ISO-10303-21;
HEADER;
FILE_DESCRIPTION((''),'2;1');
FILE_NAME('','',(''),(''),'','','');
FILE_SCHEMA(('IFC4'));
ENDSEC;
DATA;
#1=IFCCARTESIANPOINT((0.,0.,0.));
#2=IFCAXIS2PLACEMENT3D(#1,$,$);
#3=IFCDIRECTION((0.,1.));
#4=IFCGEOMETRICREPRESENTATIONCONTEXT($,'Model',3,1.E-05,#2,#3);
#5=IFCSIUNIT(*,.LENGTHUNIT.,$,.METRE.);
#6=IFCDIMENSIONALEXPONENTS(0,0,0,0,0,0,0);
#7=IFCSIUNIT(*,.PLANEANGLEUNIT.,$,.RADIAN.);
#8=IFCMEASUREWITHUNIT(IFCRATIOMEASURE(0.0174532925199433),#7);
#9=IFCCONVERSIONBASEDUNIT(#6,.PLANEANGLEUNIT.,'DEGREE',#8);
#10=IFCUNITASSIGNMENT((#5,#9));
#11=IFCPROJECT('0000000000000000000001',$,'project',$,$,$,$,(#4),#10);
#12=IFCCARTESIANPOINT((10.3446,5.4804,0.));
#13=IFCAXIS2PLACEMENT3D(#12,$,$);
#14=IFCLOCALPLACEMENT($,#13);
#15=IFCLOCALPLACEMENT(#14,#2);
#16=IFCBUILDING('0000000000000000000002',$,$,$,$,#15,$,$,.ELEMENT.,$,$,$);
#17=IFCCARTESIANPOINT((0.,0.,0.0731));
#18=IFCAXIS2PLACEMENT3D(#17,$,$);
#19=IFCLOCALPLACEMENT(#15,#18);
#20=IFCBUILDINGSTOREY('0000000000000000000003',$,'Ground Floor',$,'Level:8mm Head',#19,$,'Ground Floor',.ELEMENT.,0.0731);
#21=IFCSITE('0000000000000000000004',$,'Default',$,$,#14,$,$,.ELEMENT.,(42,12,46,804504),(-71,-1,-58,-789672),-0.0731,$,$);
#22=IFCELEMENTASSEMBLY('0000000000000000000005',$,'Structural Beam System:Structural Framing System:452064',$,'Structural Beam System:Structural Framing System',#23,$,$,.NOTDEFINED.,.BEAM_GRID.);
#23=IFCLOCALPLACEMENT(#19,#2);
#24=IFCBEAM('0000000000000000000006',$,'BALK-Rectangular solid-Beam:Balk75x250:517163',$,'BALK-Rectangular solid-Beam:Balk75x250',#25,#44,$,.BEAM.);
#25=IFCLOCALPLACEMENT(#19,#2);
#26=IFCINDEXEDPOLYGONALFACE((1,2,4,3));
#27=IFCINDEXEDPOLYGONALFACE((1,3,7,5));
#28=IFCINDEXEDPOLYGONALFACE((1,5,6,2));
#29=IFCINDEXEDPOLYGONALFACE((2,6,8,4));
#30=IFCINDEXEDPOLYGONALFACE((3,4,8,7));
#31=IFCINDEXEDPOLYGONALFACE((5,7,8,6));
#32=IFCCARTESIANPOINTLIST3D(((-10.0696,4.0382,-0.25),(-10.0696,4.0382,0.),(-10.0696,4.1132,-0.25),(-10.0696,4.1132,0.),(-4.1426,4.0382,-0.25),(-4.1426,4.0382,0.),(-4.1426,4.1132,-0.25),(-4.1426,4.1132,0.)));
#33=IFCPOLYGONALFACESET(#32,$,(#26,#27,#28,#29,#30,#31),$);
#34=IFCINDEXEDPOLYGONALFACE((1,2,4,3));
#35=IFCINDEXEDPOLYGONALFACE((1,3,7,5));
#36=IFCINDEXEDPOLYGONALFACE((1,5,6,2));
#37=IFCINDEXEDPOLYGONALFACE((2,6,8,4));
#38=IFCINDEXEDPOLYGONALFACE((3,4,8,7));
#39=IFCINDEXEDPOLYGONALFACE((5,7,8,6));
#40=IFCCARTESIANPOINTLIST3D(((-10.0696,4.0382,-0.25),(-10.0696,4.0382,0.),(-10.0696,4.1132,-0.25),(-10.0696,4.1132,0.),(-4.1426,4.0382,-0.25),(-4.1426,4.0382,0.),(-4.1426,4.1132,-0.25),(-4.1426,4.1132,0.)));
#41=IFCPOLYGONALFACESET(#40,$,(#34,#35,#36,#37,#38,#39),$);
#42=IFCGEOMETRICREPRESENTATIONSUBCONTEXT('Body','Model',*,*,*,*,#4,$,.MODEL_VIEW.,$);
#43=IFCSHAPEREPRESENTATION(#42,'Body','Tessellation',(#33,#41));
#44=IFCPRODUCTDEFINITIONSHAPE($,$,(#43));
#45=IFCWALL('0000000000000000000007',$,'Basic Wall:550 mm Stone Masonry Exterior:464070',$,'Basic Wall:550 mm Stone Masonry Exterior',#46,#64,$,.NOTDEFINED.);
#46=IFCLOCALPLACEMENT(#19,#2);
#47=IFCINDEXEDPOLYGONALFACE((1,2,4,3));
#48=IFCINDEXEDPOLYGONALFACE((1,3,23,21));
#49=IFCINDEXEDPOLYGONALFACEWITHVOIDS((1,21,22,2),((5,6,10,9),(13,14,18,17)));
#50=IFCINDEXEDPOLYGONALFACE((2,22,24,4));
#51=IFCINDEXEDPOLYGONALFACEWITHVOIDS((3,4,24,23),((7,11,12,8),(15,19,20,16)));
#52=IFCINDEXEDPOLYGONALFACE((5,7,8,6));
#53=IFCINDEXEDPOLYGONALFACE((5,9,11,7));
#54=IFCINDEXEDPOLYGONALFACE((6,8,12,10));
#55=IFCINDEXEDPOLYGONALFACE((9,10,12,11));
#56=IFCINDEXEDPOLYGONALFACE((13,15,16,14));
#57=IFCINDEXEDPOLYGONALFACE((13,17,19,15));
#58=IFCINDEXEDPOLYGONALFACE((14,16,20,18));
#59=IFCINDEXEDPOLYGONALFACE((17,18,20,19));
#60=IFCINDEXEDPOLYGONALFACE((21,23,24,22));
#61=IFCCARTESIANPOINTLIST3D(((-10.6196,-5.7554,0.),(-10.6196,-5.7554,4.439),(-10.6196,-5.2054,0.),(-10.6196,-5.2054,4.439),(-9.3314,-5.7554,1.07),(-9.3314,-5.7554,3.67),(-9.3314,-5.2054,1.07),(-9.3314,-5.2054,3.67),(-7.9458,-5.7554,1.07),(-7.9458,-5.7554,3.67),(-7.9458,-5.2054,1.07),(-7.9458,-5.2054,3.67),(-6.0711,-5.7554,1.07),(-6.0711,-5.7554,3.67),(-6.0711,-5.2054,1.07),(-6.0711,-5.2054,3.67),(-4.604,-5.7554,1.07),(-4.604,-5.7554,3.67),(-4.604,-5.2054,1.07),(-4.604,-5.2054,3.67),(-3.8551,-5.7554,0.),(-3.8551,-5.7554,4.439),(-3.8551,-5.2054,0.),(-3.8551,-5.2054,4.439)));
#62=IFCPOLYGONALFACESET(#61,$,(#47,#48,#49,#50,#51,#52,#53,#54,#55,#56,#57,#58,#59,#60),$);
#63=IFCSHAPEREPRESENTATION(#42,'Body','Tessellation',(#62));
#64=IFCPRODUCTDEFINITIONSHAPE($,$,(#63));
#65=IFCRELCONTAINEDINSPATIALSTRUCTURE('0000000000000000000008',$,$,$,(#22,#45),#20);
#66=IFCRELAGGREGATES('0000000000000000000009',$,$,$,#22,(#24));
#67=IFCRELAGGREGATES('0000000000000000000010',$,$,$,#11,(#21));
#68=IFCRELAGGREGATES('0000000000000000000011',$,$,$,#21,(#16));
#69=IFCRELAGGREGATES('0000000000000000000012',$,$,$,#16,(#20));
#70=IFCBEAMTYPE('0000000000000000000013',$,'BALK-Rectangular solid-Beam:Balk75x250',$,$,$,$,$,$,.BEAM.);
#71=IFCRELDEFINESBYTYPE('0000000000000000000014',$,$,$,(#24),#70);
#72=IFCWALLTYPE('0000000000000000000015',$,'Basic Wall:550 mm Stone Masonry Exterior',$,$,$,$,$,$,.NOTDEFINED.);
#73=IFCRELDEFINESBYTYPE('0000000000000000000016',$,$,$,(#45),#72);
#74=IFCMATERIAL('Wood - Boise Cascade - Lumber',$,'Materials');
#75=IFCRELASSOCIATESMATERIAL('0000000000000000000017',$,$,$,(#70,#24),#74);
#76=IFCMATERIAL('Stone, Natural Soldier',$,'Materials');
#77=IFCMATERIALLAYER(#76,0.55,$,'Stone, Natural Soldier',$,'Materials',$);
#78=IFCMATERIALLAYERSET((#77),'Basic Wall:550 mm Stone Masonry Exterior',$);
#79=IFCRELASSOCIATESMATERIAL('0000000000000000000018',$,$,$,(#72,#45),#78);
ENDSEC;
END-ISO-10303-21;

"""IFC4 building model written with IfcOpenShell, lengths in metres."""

from ifc_helpers import new_model, entity, si_unit, converted_unit, direction, frame, frame_2d, origin, origin_2d_with_axis, place, context, subcontext, project, spatial, rectangle, extrude, source, transform, mapped, material, layer, layer_set, layer_usage, material_profile, profile_set, profile_usage, type_object, type_shapes, element, aggregate, save


model = new_model("IFC4")

# Units and contexts
model_context = context("Model", 3, precision=1e-05, world=origin(), true_north=direction((0.0, 1.0)))
body_context = subcontext(model_context, "Body", "Model", "MODEL_VIEW")
ifc_project = project(units=[si_unit("LENGTHUNIT", "METRE"), converted_unit("PLANEANGLEUNIT", "DEGREE", entity("IfcRatioMeasure", 0.0174532925199433), si_unit("PLANEANGLEUNIT", "RADIAN"), dimensions=[0, 0, 0, 0, 0, 0, 0])], contexts=[model_context])

# Site, building, storey
site_placement = place(None, frame((10.3446, 5.4804, 0.0)))
site = spatial("IfcSite", under=ifc_project, at=site_placement, Name="Default", CompositionType="ELEMENT", RefLatitude=(42, 12, 46, 804504), RefLongitude=(-71, -1, -58, -789672), RefElevation=-0.0731)
building_placement = place(site_placement, origin())
building = spatial("IfcBuilding", under=site, at=building_placement, CompositionType="ELEMENT")
storey_placement = place(building_placement, frame((0.0, 0.0, 0.0731)))
storey = spatial("IfcBuildingStorey", under=building, at=storey_placement, Name="Ground Floor", ObjectType="Level:8mm Head", LongName="Ground Floor", CompositionType="ELEMENT", Elevation=0.0731)

# Element assembly, beam
assembly_placement = place(storey_placement, origin())
assembly = element("IfcElementAssembly", 1, at=assembly_placement, inside=storey, Name="Structural Beam System:Structural Framing System:452064", ObjectType="Structural Beam System:Structural Framing System", AssemblyPlace="NOTDEFINED", PredefinedType="BEAM_GRID")
ifc_material_1 = material(Name="Wood - Boise Cascade - Lumber", Category="Materials")
ifc_material_profile = material_profile(ifc_material_1, rectangle(XDim=0.25, YDim=0.075, at=frame_2d((0.0, 0.0), x_axis=(1.0, 0.0))), Name="Balk75x250")
ifc_profile_set = profile_set([ifc_material_profile], Name="Balk75x250")
beam_type = type_object("IfcBeamType", Name="BALK-Rectangular solid-Beam:Balk75x250", PredefinedType="BEAM", material=ifc_profile_set)
shared_shape = source(origin(), body_context, "Body", "SweptSolid", [
    extrude(rectangle(XDim=0.25, YDim=0.075, at=origin_2d_with_axis()), frame((-2.9573, 0.0, 0.0), z_axis=(1.0, 0.0, 0.0), x_axis=(0.0, 0.0, -1.0)), (0.0, 0.0, 1.0), 5.927),
    extrude(rectangle(XDim=0.25, YDim=0.075, at=origin_2d_with_axis()), frame((-2.9573, 0.0, 0.0), z_axis=(1.0, 0.0, 0.0), x_axis=(0.0, 0.0, -1.0)), (0.0, 0.0, 1.0), 5.927),
])
type_shapes(beam_type, [shared_shape])
ifc_profile_usage_1 = profile_usage(ifc_profile_set, cardinal=8)
beam_1_placement = place(assembly_placement, frame((-7.0999, 4.0757, -0.125), z_axis=(0.0, 0.0, 1.0), x_axis=(-1.0, 0.0, 0.0)))
beam_1 = element("IfcBeam", 2, at=beam_1_placement, type_object=beam_type, material=ifc_profile_usage_1, Name="BALK-Rectangular solid-Beam:Balk75x250:517163", ObjectType="BALK-Rectangular solid-Beam:Balk75x250", PredefinedType="BEAM", context=body_context, shape_type="MappedRepresentation", body=[
    mapped(shared_shape, transform((0.0, 0.0, 0.0), scale=1.0)),
])
aggregate(assembly, [beam_1])

# Wall, openings
ifc_material_2 = material(Name="Stone, Natural Soldier", Category="Materials")
ifc_layer = layer(ifc_material_2, 0.55, Name="Stone, Natural Soldier", Category="Materials")
ifc_layer_set = layer_set([ifc_layer], Name="Basic Wall:550 mm Stone Masonry Exterior")
ifc_layer_usage = layer_usage(ifc_layer_set, "AXIS2", "NEGATIVE", 0.275)
wall_type = type_object("IfcWallType", Name="Basic Wall:550 mm Stone Masonry Exterior", PredefinedType="NOTDEFINED", material=ifc_layer_set)
wall_placement = place(storey_placement, frame((-10.6196, -5.4804, 0.0)))
wall = element("IfcWall", 3, at=wall_placement, inside=storey, type_object=wall_type, material=ifc_layer_usage, Name="Basic Wall:550 mm Stone Masonry Exterior:464070", ObjectType="Basic Wall:550 mm Stone Masonry Exterior", PredefinedType="NOTDEFINED", context=body_context, shape_type="SweptSolid", body=[
    extrude(rectangle(XDim=6.7645, YDim=0.55, at=frame_2d((3.3823, 0.0), x_axis=(-1.0, 0.0))), origin(), (0.0, 0.0, 1.0), 4.439),
])
opening_1_placement = place(wall_placement, frame((1.2883, -0.275, 1.07)))
element("IfcOpeningElement", 4, at=opening_1_placement, cuts=wall, ObjectType="Opening", PredefinedType="OPENING", context=body_context, shape_type="SweptSolid", body=[
    extrude(rectangle(XDim=2.6, YDim=1.3856, at=frame_2d((0.0, 0.0), x_axis=(1.0, 0.0))), frame((0.6928, 0.0, 1.3), z_axis=(0.0, 1.0, 0.0), x_axis=(0.0, 0.0, -1.0)), (0.0, 0.0, 1.0), 0.55),
])
opening_2_placement = place(wall_placement, frame((4.5485, -0.275, 1.07)))
element("IfcOpeningElement", 5, at=opening_2_placement, cuts=wall, ObjectType="Opening", PredefinedType="OPENING", context=body_context, shape_type="SweptSolid", body=[
    extrude(rectangle(XDim=2.6, YDim=1.4671, at=frame_2d((0.0, 0.0), x_axis=(1.0, 0.0))), frame((0.7336, 0.0, 1.3), z_axis=(0.0, 1.0, 0.0), x_axis=(0.0, 0.0, -1.0)), (0.0, 0.0, 1.0), 0.55),
])

save(model, "model.ifc")
